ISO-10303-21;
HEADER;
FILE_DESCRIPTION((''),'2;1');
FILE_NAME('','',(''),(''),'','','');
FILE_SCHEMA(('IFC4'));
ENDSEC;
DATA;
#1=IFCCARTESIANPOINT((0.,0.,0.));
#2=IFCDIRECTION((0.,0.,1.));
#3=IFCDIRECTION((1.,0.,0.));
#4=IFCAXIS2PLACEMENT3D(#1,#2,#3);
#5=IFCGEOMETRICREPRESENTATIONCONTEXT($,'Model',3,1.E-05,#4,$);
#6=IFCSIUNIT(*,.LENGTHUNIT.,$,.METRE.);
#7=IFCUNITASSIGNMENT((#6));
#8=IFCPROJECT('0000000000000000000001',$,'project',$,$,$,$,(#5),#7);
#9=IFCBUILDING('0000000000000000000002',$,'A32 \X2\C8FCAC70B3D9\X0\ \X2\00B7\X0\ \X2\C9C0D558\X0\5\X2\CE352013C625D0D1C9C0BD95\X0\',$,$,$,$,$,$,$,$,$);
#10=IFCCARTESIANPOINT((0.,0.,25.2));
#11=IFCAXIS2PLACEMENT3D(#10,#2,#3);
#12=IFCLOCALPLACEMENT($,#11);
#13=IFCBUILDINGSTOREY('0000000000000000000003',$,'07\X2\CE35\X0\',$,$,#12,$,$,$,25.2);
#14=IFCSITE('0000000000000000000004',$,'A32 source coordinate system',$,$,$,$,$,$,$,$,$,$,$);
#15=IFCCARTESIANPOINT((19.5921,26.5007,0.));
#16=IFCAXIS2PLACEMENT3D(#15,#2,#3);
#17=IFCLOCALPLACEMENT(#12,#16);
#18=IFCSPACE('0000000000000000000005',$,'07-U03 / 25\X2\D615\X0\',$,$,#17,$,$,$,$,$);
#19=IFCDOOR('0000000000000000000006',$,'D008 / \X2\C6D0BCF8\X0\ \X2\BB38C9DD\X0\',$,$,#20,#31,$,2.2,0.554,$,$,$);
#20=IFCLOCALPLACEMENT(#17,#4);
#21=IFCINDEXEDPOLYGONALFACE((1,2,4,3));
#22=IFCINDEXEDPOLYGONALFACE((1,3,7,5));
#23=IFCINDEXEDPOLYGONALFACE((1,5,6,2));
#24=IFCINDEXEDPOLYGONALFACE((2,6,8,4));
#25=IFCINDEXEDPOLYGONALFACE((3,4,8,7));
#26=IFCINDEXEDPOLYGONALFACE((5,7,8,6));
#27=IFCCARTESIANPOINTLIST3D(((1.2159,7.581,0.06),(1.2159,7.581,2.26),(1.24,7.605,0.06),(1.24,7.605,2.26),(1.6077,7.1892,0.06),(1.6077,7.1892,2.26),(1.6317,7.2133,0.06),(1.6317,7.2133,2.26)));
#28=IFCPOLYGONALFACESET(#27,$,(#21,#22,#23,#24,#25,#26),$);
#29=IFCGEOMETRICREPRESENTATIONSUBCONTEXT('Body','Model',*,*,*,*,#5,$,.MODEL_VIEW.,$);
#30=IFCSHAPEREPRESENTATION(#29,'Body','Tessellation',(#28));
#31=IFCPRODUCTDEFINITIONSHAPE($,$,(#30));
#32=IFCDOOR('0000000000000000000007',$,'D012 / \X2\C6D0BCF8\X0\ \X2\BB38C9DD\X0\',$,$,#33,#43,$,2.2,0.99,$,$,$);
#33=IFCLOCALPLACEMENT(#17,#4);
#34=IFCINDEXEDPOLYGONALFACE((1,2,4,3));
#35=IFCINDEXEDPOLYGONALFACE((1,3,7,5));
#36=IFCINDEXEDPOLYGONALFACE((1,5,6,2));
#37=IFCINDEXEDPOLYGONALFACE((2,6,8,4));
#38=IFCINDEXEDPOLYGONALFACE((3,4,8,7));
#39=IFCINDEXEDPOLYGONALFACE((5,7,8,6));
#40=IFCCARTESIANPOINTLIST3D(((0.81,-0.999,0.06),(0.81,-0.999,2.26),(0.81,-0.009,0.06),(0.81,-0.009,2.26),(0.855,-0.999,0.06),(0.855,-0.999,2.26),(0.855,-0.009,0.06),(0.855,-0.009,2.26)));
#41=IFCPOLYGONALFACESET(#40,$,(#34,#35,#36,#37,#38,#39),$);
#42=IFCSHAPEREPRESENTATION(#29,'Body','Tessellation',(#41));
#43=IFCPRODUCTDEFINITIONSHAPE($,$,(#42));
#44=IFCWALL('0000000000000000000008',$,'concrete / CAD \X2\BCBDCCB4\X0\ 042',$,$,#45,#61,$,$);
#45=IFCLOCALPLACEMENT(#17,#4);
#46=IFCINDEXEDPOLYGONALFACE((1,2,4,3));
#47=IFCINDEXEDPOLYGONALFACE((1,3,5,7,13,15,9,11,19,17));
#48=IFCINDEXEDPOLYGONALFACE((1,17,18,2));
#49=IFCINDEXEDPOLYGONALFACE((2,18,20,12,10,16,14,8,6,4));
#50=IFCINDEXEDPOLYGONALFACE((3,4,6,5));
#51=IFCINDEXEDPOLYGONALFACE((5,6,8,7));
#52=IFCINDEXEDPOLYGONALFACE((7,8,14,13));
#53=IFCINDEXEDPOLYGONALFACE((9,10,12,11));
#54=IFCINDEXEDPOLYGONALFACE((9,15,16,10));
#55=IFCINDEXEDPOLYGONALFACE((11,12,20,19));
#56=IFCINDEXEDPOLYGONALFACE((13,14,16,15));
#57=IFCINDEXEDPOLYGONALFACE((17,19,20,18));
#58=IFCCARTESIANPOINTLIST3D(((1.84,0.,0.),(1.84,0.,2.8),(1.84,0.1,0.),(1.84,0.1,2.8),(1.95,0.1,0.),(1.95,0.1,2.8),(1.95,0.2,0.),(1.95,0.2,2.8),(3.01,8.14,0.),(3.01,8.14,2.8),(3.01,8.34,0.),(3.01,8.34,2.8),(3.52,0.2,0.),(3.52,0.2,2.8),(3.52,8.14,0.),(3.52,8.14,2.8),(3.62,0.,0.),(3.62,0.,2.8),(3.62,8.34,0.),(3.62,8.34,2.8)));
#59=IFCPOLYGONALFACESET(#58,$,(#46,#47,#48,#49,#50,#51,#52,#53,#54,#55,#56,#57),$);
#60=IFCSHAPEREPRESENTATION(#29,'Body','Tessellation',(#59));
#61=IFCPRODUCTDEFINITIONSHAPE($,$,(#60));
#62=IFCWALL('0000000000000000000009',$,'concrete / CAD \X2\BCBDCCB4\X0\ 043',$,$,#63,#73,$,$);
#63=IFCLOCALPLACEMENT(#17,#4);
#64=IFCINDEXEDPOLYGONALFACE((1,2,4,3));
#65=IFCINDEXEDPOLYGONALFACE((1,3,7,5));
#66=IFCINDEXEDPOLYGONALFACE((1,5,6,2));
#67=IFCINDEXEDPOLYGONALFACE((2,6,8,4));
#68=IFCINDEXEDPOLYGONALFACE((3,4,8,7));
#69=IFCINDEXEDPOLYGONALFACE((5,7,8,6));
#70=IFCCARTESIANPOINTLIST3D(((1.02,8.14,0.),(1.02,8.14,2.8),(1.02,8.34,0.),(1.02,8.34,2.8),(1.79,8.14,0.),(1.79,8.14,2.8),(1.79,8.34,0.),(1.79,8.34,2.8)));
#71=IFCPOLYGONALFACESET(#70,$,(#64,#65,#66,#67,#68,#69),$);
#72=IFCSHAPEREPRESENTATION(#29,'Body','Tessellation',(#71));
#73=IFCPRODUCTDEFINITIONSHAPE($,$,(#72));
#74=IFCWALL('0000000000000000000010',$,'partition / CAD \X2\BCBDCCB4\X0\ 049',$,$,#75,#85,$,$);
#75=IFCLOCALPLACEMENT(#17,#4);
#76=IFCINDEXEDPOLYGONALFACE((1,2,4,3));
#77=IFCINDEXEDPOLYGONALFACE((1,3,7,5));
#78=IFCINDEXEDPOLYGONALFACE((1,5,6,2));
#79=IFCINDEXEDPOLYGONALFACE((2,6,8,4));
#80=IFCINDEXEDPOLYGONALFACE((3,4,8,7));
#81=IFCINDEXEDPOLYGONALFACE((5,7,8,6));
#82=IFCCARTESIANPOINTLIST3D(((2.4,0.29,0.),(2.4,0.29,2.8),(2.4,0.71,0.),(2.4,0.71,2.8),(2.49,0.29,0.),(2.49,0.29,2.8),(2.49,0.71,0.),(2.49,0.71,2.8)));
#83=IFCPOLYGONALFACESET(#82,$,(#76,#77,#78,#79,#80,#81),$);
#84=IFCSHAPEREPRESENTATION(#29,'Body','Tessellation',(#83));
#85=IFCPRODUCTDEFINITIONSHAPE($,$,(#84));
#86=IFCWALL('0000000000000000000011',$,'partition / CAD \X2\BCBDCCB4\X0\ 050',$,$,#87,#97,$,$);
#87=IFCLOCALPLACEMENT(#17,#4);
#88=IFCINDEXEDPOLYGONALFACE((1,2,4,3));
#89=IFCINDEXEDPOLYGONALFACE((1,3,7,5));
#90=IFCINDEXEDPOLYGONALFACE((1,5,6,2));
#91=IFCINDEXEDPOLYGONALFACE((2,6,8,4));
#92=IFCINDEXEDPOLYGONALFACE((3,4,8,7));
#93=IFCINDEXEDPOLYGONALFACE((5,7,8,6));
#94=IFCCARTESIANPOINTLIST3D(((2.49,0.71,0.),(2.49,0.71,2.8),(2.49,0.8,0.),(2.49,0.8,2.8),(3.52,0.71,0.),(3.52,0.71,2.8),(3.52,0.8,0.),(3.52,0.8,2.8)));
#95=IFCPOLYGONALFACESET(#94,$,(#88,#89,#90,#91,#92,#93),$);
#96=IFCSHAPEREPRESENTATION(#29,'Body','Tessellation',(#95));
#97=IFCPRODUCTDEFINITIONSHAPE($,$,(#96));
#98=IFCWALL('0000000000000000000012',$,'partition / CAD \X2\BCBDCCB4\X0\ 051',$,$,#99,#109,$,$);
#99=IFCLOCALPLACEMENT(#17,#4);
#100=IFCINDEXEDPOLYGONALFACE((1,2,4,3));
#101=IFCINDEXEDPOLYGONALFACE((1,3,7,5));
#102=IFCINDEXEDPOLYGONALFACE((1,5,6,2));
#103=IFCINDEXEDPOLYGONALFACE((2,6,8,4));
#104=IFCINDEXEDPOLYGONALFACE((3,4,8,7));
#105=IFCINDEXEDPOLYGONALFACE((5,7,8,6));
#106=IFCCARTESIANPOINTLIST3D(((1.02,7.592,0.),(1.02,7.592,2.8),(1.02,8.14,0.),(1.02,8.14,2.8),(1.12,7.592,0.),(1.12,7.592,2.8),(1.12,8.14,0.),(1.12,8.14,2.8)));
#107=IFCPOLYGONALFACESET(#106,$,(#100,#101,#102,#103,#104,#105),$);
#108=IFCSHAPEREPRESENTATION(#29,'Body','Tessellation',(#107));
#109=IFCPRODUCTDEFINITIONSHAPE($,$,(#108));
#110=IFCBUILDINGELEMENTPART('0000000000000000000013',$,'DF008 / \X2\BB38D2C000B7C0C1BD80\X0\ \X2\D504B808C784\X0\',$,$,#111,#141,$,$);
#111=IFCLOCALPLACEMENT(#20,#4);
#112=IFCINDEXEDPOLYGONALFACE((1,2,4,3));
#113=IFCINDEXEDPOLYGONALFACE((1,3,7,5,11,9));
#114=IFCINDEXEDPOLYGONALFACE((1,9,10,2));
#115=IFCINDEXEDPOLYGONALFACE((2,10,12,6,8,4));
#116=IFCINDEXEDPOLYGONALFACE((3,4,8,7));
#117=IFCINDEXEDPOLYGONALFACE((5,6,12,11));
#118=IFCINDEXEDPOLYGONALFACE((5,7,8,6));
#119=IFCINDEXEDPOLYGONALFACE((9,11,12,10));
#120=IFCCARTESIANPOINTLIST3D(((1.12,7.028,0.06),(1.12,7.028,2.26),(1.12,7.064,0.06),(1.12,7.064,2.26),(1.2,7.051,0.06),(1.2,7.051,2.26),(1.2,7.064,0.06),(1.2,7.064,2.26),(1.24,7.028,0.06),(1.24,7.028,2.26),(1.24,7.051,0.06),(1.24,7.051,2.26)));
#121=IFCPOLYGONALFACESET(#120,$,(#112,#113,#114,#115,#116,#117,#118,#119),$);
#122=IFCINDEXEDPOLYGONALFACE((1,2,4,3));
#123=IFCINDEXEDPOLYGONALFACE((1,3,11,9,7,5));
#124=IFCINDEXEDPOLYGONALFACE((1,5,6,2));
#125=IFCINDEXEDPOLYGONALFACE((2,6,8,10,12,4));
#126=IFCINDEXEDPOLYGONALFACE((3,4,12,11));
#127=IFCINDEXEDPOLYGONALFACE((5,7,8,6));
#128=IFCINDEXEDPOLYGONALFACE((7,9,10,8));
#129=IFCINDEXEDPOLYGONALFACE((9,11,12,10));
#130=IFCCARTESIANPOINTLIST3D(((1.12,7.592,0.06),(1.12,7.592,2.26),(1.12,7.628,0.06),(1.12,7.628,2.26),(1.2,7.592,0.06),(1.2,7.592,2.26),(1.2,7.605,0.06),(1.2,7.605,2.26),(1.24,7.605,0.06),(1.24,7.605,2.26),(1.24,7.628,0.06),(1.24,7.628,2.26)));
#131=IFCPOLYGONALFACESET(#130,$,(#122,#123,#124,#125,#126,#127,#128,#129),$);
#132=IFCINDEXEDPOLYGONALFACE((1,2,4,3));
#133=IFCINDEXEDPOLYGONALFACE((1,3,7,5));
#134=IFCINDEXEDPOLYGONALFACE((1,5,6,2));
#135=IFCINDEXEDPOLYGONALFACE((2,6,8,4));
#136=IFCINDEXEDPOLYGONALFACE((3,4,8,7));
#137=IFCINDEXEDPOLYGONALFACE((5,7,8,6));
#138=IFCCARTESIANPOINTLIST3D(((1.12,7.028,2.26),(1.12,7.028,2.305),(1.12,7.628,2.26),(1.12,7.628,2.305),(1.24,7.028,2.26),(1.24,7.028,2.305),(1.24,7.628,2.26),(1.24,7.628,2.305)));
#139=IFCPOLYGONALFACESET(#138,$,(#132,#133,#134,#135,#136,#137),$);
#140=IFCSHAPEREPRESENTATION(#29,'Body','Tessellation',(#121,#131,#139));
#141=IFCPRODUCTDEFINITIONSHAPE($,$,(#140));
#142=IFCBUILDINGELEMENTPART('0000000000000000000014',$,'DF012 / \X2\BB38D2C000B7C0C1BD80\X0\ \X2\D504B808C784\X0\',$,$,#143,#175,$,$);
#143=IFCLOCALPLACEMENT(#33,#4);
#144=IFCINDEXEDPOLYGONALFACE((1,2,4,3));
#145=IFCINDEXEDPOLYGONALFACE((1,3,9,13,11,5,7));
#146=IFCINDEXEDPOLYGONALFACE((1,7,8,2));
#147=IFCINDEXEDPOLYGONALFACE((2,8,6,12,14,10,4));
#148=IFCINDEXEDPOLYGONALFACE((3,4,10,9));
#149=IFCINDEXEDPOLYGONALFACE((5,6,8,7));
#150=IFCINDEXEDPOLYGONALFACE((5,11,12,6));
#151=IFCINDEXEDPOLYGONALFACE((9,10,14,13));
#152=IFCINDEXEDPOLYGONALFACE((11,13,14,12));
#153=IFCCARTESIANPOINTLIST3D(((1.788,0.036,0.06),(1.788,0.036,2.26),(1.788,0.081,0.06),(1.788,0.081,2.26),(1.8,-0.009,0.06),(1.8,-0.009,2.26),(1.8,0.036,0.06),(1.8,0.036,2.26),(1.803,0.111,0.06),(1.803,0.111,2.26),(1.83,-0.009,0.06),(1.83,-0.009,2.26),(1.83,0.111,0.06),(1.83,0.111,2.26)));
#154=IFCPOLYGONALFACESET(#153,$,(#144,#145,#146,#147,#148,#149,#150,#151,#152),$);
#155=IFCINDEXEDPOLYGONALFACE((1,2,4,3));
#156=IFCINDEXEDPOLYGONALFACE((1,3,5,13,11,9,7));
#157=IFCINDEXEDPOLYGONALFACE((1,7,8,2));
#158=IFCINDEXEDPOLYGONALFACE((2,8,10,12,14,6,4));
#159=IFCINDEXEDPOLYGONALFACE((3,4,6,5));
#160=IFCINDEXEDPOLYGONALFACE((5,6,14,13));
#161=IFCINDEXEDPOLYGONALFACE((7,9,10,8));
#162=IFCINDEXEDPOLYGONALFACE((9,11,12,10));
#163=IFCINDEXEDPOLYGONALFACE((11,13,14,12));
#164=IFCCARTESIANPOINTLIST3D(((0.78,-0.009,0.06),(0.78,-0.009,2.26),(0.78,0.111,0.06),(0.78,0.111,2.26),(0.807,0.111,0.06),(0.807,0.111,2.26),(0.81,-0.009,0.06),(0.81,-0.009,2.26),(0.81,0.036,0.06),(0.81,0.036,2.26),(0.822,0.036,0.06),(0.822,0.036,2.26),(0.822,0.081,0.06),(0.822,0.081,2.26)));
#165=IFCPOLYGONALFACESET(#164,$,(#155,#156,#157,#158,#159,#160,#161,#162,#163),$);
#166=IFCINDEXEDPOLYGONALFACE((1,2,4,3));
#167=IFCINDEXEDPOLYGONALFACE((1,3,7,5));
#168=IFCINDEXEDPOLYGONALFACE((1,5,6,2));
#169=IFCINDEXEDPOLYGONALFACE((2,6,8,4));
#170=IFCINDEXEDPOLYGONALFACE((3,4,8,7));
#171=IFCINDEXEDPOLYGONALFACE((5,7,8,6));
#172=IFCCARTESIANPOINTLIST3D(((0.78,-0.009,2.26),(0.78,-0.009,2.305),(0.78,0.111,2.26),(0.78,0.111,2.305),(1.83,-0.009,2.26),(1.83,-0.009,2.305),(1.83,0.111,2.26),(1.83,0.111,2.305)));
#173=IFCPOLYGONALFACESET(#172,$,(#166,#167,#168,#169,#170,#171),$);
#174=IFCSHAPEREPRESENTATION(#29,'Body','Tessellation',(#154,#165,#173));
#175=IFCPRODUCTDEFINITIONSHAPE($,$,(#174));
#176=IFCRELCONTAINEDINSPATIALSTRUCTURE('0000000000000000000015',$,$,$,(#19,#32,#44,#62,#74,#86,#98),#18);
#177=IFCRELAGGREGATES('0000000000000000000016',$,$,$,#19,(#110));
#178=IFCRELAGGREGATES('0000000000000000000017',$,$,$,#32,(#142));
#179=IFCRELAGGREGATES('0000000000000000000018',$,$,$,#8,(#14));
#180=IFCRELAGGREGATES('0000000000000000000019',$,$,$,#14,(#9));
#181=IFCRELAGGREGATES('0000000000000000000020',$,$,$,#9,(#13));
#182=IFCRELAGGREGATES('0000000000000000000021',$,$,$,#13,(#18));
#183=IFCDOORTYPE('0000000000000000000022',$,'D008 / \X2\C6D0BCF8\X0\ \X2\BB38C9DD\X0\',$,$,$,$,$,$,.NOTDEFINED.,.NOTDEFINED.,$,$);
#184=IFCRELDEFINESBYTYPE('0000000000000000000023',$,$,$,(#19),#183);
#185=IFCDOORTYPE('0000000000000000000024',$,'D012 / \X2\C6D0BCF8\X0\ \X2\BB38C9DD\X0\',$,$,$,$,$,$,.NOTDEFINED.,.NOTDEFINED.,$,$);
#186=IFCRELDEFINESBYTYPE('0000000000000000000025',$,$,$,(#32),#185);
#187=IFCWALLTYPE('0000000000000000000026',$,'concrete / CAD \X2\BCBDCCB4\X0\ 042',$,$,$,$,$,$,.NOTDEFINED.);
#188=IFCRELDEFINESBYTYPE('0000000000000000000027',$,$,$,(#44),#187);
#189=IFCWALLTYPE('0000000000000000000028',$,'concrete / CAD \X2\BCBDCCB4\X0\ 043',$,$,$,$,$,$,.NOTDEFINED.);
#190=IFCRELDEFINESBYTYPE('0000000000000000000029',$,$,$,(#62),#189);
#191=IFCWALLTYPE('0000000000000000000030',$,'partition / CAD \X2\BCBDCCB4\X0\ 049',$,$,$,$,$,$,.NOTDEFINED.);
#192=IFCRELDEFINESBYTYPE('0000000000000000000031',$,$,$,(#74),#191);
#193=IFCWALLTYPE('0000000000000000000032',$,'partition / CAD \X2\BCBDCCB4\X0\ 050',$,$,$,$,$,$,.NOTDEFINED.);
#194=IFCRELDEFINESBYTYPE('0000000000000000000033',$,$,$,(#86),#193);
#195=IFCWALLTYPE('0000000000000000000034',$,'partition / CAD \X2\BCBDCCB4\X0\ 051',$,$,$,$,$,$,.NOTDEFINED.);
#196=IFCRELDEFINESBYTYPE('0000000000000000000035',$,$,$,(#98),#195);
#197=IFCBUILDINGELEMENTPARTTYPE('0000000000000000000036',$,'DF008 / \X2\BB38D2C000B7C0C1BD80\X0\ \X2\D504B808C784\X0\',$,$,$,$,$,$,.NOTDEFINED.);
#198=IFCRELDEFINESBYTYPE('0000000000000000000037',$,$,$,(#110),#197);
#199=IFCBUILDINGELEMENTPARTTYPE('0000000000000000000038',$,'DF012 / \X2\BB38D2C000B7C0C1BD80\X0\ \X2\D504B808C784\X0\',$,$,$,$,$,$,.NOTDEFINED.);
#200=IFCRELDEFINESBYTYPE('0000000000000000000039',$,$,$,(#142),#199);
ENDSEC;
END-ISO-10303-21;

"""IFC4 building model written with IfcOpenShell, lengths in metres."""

from ifc_helpers import new_model, si_unit, frame, origin, origin_with_axes, place, context, subcontext, project, spatial, polyline, outline, extrude, source, transform, mapped, type_object, type_shapes, element, aggregate, save


model = new_model("IFC4")

# Units and contexts
model_context = context("Model", 3, precision=1e-05, world=origin_with_axes())
body_context = subcontext(model_context, "Body", "Model", "MODEL_VIEW")
ifc_project = project(units=[si_unit("LENGTHUNIT", "METRE")], contexts=[model_context])

# Site, building, storey, space
storey_placement = place(None, frame((0.0, 0.0, 25.2), z_axis=(0.0, 0.0, 1.0), x_axis=(1.0, 0.0, 0.0)))
space_placement = place(storey_placement, frame((19.5921, 26.5007, 0.0), z_axis=(0.0, 0.0, 1.0), x_axis=(1.0, 0.0, 0.0)))
site = spatial("IfcSite", under=ifc_project, Name="A32 source coordinate system")
building = spatial("IfcBuilding", under=site, Name="A32 주거동 · 지하5층–옥탑지붕")
storey = spatial("IfcBuildingStorey", under=building, at=storey_placement, Name="07층", Elevation=25.2)
space = spatial("IfcSpace", under=storey, at=space_placement, Name="07-U03 / 25형")

# Doors
door_type_1 = type_object("IfcDoorType", Name="D008 / 원본 문짝", OperationType="NOTDEFINED", PredefinedType="NOTDEFINED")
shared_shape_1 = source(origin(), body_context, "Body", "SweptSolid", [
    extrude(outline(polyline([(1.24, 7.605), (1.6317, 7.2133), (1.6077, 7.1892), (1.2159, 7.581), (1.24, 7.605)])), frame((0.0, 0.0, 0.06)), (0.0, 0.0, 1.0), 2.2),
])
type_shapes(door_type_1, [shared_shape_1])
door_1_placement = place(space_placement, origin_with_axes())
door_1 = element("IfcDoor", 1, at=door_1_placement, inside=space, type_object=door_type_1, Name="D008 / 원본 문짝", OverallHeight=2.2, OverallWidth=0.554, context=body_context, shape_type="MappedRepresentation", body=[
    mapped(shared_shape_1, transform((0.0, 0.0, 0.0), scale=1.0)),
])
door_type_2 = type_object("IfcDoorType", Name="D012 / 원본 문짝", OperationType="NOTDEFINED", PredefinedType="NOTDEFINED")
shared_shape_2 = source(origin(), body_context, "Body", "SweptSolid", [
    extrude(outline(polyline([(0.855, -0.999), (0.81, -0.999), (0.81, -0.009), (0.855, -0.009), (0.855, -0.999)])), frame((0.0, 0.0, 0.06)), (0.0, 0.0, 1.0), 2.2),
])
type_shapes(door_type_2, [shared_shape_2])
door_2_placement = place(space_placement, origin_with_axes())
door_2 = element("IfcDoor", 2, at=door_2_placement, inside=space, type_object=door_type_2, Name="D012 / 원본 문짝", OverallHeight=2.2, OverallWidth=0.99, context=body_context, shape_type="MappedRepresentation", body=[
    mapped(shared_shape_2, transform((0.0, 0.0, 0.0), scale=1.0)),
])

# Walls
wall_type_1 = type_object("IfcWallType", Name="concrete / CAD 벽체 042", PredefinedType="NOTDEFINED")
shared_shape_3 = source(origin(), body_context, "Body", "SweptSolid", [
    extrude(outline(polyline([(3.01, 8.34), (3.97, 8.34), (3.97, 8.34), (3.62, 8.34), (3.62, 0.0), (1.84, 0.0), (1.84, 0.1), (1.95, 0.1), (1.95, 0.2), (3.52, 0.2), (3.52, 8.14), (3.01, 8.14), (3.01, 8.34)])), origin(), (0.0, 0.0, 1.0), 2.8),
])
type_shapes(wall_type_1, [shared_shape_3])
wall_1_placement = place(space_placement, origin_with_axes())
element("IfcWall", 3, at=wall_1_placement, inside=space, type_object=wall_type_1, Name="concrete / CAD 벽체 042", context=body_context, shape_type="MappedRepresentation", body=[
    mapped(shared_shape_3, transform((0.0, 0.0, 0.0), scale=1.0)),
])
wall_type_2 = type_object("IfcWallType", Name="concrete / CAD 벽체 043", PredefinedType="NOTDEFINED")
shared_shape_4 = source(origin(), body_context, "Body", "SweptSolid", [
    extrude(outline(polyline([(1.79, 8.14), (1.02, 8.14), (1.02, 8.34), (1.79, 8.34), (1.79, 8.14)])), origin(), (0.0, 0.0, 1.0), 2.8),
])
type_shapes(wall_type_2, [shared_shape_4])
wall_2_placement = place(space_placement, origin_with_axes())
element("IfcWall", 4, at=wall_2_placement, inside=space, type_object=wall_type_2, Name="concrete / CAD 벽체 043", context=body_context, shape_type="MappedRepresentation", body=[
    mapped(shared_shape_4, transform((0.0, 0.0, 0.0), scale=1.0)),
])
wall_type_3 = type_object("IfcWallType", Name="partition / CAD 벽체 049", PredefinedType="NOTDEFINED")
shared_shape_5 = source(origin(), body_context, "Body", "SweptSolid", [
    extrude(outline(polyline([(2.49, 0.29), (2.4, 0.29), (2.4, 0.71), (2.49, 0.71), (2.49, 0.29)])), origin(), (0.0, 0.0, 1.0), 2.8),
])
type_shapes(wall_type_3, [shared_shape_5])
wall_3_placement = place(space_placement, origin_with_axes())
element("IfcWall", 5, at=wall_3_placement, inside=space, type_object=wall_type_3, Name="partition / CAD 벽체 049", context=body_context, shape_type="MappedRepresentation", body=[
    mapped(shared_shape_5, transform((0.0, 0.0, 0.0), scale=1.0)),
])
wall_type_4 = type_object("IfcWallType", Name="partition / CAD 벽체 050", PredefinedType="NOTDEFINED")
shared_shape_6 = source(origin(), body_context, "Body", "SweptSolid", [
    extrude(outline(polyline([(2.49, 0.71), (2.49, 0.8), (3.52, 0.8), (3.52, 0.71), (2.49, 0.71)])), origin(), (0.0, 0.0, 1.0), 2.8),
])
type_shapes(wall_type_4, [shared_shape_6])
wall_4_placement = place(space_placement, origin_with_axes())
element("IfcWall", 6, at=wall_4_placement, inside=space, type_object=wall_type_4, Name="partition / CAD 벽체 050", context=body_context, shape_type="MappedRepresentation", body=[
    mapped(shared_shape_6, transform((0.0, 0.0, 0.0), scale=1.0)),
])
wall_type_5 = type_object("IfcWallType", Name="partition / CAD 벽체 051", PredefinedType="NOTDEFINED")
shared_shape_7 = source(origin(), body_context, "Body", "SweptSolid", [
    extrude(outline(polyline([(1.02, 8.14), (1.12, 8.14), (1.12, 7.592), (1.02, 7.592), (1.02, 8.14)])), origin(), (0.0, 0.0, 1.0), 2.8),
])
type_shapes(wall_type_5, [shared_shape_7])
wall_5_placement = place(space_placement, origin_with_axes())
element("IfcWall", 7, at=wall_5_placement, inside=space, type_object=wall_type_5, Name="partition / CAD 벽체 051", context=body_context, shape_type="MappedRepresentation", body=[
    mapped(shared_shape_7, transform((0.0, 0.0, 0.0), scale=1.0)),
])

# Building element parts
building_element_part_type_1 = type_object("IfcBuildingElementPartType", Name="DF008 / 문틀·상부 프레임", PredefinedType="NOTDEFINED")
shared_shape_8 = source(origin(), body_context, "Body", "SweptSolid", [
    extrude(outline(polyline([(1.12, 7.064), (1.2, 7.064), (1.2, 7.051), (1.24, 7.051), (1.24, 7.028), (1.12, 7.028), (1.12, 7.064)])), frame((0.0, 0.0, 0.06)), (0.0, 0.0, 1.0), 2.2),
    extrude(outline(polyline([(1.24, 7.628), (1.24, 7.605), (1.2, 7.605), (1.2, 7.592), (1.12, 7.592), (1.12, 7.628), (1.24, 7.628)])), frame((0.0, 0.0, 0.06)), (0.0, 0.0, 1.0), 2.2),
    extrude(outline(polyline([(1.12, 7.028), (1.12, 7.628), (1.24, 7.628), (1.24, 7.028), (1.12, 7.028)])), frame((0.0, 0.0, 2.26)), (0.0, 0.0, 1.0), 0.045),
])
type_shapes(building_element_part_type_1, [shared_shape_8])
building_element_part_1_placement = place(door_1_placement, origin_with_axes())
building_element_part_1 = element("IfcBuildingElementPart", 8, at=building_element_part_1_placement, type_object=building_element_part_type_1, Name="DF008 / 문틀·상부 프레임", context=body_context, shape_type="MappedRepresentation", body=[
    mapped(shared_shape_8, transform((0.0, 0.0, 0.0), scale=1.0)),
])
aggregate(door_1, [building_element_part_1])
building_element_part_type_2 = type_object("IfcBuildingElementPartType", Name="DF012 / 문틀·상부 프레임", PredefinedType="NOTDEFINED")
shared_shape_9 = source(origin(), body_context, "Body", "SweptSolid", [
    extrude(outline(polyline([(1.8, -0.009), (1.8, 0.036), (1.788, 0.036), (1.788, 0.081), (1.803, 0.111), (1.83, 0.111), (1.83, -0.009), (1.8, -0.009)])), frame((0.0, 0.0, 0.06)), (0.0, 0.0, 1.0), 2.2),
    extrude(outline(polyline([(0.78, 0.111), (0.807, 0.111), (0.822, 0.081), (0.822, 0.036), (0.81, 0.036), (0.81, -0.009), (0.78, -0.009), (0.78, 0.111)])), frame((0.0, 0.0, 0.06)), (0.0, 0.0, 1.0), 2.2),
    extrude(outline(polyline([(0.78, -0.009), (0.78, 0.111), (1.83, 0.111), (1.83, -0.009), (0.78, -0.009)])), frame((0.0, 0.0, 2.26)), (0.0, 0.0, 1.0), 0.045),
])
type_shapes(building_element_part_type_2, [shared_shape_9])
building_element_part_2_placement = place(door_2_placement, origin_with_axes())
building_element_part_2 = element("IfcBuildingElementPart", 9, at=building_element_part_2_placement, type_object=building_element_part_type_2, Name="DF012 / 문틀·상부 프레임", context=body_context, shape_type="MappedRepresentation", body=[
    mapped(shared_shape_9, transform((0.0, 0.0, 0.0), scale=1.0)),
])
aggregate(door_2, [building_element_part_2])

save(model, "model.ifc")
